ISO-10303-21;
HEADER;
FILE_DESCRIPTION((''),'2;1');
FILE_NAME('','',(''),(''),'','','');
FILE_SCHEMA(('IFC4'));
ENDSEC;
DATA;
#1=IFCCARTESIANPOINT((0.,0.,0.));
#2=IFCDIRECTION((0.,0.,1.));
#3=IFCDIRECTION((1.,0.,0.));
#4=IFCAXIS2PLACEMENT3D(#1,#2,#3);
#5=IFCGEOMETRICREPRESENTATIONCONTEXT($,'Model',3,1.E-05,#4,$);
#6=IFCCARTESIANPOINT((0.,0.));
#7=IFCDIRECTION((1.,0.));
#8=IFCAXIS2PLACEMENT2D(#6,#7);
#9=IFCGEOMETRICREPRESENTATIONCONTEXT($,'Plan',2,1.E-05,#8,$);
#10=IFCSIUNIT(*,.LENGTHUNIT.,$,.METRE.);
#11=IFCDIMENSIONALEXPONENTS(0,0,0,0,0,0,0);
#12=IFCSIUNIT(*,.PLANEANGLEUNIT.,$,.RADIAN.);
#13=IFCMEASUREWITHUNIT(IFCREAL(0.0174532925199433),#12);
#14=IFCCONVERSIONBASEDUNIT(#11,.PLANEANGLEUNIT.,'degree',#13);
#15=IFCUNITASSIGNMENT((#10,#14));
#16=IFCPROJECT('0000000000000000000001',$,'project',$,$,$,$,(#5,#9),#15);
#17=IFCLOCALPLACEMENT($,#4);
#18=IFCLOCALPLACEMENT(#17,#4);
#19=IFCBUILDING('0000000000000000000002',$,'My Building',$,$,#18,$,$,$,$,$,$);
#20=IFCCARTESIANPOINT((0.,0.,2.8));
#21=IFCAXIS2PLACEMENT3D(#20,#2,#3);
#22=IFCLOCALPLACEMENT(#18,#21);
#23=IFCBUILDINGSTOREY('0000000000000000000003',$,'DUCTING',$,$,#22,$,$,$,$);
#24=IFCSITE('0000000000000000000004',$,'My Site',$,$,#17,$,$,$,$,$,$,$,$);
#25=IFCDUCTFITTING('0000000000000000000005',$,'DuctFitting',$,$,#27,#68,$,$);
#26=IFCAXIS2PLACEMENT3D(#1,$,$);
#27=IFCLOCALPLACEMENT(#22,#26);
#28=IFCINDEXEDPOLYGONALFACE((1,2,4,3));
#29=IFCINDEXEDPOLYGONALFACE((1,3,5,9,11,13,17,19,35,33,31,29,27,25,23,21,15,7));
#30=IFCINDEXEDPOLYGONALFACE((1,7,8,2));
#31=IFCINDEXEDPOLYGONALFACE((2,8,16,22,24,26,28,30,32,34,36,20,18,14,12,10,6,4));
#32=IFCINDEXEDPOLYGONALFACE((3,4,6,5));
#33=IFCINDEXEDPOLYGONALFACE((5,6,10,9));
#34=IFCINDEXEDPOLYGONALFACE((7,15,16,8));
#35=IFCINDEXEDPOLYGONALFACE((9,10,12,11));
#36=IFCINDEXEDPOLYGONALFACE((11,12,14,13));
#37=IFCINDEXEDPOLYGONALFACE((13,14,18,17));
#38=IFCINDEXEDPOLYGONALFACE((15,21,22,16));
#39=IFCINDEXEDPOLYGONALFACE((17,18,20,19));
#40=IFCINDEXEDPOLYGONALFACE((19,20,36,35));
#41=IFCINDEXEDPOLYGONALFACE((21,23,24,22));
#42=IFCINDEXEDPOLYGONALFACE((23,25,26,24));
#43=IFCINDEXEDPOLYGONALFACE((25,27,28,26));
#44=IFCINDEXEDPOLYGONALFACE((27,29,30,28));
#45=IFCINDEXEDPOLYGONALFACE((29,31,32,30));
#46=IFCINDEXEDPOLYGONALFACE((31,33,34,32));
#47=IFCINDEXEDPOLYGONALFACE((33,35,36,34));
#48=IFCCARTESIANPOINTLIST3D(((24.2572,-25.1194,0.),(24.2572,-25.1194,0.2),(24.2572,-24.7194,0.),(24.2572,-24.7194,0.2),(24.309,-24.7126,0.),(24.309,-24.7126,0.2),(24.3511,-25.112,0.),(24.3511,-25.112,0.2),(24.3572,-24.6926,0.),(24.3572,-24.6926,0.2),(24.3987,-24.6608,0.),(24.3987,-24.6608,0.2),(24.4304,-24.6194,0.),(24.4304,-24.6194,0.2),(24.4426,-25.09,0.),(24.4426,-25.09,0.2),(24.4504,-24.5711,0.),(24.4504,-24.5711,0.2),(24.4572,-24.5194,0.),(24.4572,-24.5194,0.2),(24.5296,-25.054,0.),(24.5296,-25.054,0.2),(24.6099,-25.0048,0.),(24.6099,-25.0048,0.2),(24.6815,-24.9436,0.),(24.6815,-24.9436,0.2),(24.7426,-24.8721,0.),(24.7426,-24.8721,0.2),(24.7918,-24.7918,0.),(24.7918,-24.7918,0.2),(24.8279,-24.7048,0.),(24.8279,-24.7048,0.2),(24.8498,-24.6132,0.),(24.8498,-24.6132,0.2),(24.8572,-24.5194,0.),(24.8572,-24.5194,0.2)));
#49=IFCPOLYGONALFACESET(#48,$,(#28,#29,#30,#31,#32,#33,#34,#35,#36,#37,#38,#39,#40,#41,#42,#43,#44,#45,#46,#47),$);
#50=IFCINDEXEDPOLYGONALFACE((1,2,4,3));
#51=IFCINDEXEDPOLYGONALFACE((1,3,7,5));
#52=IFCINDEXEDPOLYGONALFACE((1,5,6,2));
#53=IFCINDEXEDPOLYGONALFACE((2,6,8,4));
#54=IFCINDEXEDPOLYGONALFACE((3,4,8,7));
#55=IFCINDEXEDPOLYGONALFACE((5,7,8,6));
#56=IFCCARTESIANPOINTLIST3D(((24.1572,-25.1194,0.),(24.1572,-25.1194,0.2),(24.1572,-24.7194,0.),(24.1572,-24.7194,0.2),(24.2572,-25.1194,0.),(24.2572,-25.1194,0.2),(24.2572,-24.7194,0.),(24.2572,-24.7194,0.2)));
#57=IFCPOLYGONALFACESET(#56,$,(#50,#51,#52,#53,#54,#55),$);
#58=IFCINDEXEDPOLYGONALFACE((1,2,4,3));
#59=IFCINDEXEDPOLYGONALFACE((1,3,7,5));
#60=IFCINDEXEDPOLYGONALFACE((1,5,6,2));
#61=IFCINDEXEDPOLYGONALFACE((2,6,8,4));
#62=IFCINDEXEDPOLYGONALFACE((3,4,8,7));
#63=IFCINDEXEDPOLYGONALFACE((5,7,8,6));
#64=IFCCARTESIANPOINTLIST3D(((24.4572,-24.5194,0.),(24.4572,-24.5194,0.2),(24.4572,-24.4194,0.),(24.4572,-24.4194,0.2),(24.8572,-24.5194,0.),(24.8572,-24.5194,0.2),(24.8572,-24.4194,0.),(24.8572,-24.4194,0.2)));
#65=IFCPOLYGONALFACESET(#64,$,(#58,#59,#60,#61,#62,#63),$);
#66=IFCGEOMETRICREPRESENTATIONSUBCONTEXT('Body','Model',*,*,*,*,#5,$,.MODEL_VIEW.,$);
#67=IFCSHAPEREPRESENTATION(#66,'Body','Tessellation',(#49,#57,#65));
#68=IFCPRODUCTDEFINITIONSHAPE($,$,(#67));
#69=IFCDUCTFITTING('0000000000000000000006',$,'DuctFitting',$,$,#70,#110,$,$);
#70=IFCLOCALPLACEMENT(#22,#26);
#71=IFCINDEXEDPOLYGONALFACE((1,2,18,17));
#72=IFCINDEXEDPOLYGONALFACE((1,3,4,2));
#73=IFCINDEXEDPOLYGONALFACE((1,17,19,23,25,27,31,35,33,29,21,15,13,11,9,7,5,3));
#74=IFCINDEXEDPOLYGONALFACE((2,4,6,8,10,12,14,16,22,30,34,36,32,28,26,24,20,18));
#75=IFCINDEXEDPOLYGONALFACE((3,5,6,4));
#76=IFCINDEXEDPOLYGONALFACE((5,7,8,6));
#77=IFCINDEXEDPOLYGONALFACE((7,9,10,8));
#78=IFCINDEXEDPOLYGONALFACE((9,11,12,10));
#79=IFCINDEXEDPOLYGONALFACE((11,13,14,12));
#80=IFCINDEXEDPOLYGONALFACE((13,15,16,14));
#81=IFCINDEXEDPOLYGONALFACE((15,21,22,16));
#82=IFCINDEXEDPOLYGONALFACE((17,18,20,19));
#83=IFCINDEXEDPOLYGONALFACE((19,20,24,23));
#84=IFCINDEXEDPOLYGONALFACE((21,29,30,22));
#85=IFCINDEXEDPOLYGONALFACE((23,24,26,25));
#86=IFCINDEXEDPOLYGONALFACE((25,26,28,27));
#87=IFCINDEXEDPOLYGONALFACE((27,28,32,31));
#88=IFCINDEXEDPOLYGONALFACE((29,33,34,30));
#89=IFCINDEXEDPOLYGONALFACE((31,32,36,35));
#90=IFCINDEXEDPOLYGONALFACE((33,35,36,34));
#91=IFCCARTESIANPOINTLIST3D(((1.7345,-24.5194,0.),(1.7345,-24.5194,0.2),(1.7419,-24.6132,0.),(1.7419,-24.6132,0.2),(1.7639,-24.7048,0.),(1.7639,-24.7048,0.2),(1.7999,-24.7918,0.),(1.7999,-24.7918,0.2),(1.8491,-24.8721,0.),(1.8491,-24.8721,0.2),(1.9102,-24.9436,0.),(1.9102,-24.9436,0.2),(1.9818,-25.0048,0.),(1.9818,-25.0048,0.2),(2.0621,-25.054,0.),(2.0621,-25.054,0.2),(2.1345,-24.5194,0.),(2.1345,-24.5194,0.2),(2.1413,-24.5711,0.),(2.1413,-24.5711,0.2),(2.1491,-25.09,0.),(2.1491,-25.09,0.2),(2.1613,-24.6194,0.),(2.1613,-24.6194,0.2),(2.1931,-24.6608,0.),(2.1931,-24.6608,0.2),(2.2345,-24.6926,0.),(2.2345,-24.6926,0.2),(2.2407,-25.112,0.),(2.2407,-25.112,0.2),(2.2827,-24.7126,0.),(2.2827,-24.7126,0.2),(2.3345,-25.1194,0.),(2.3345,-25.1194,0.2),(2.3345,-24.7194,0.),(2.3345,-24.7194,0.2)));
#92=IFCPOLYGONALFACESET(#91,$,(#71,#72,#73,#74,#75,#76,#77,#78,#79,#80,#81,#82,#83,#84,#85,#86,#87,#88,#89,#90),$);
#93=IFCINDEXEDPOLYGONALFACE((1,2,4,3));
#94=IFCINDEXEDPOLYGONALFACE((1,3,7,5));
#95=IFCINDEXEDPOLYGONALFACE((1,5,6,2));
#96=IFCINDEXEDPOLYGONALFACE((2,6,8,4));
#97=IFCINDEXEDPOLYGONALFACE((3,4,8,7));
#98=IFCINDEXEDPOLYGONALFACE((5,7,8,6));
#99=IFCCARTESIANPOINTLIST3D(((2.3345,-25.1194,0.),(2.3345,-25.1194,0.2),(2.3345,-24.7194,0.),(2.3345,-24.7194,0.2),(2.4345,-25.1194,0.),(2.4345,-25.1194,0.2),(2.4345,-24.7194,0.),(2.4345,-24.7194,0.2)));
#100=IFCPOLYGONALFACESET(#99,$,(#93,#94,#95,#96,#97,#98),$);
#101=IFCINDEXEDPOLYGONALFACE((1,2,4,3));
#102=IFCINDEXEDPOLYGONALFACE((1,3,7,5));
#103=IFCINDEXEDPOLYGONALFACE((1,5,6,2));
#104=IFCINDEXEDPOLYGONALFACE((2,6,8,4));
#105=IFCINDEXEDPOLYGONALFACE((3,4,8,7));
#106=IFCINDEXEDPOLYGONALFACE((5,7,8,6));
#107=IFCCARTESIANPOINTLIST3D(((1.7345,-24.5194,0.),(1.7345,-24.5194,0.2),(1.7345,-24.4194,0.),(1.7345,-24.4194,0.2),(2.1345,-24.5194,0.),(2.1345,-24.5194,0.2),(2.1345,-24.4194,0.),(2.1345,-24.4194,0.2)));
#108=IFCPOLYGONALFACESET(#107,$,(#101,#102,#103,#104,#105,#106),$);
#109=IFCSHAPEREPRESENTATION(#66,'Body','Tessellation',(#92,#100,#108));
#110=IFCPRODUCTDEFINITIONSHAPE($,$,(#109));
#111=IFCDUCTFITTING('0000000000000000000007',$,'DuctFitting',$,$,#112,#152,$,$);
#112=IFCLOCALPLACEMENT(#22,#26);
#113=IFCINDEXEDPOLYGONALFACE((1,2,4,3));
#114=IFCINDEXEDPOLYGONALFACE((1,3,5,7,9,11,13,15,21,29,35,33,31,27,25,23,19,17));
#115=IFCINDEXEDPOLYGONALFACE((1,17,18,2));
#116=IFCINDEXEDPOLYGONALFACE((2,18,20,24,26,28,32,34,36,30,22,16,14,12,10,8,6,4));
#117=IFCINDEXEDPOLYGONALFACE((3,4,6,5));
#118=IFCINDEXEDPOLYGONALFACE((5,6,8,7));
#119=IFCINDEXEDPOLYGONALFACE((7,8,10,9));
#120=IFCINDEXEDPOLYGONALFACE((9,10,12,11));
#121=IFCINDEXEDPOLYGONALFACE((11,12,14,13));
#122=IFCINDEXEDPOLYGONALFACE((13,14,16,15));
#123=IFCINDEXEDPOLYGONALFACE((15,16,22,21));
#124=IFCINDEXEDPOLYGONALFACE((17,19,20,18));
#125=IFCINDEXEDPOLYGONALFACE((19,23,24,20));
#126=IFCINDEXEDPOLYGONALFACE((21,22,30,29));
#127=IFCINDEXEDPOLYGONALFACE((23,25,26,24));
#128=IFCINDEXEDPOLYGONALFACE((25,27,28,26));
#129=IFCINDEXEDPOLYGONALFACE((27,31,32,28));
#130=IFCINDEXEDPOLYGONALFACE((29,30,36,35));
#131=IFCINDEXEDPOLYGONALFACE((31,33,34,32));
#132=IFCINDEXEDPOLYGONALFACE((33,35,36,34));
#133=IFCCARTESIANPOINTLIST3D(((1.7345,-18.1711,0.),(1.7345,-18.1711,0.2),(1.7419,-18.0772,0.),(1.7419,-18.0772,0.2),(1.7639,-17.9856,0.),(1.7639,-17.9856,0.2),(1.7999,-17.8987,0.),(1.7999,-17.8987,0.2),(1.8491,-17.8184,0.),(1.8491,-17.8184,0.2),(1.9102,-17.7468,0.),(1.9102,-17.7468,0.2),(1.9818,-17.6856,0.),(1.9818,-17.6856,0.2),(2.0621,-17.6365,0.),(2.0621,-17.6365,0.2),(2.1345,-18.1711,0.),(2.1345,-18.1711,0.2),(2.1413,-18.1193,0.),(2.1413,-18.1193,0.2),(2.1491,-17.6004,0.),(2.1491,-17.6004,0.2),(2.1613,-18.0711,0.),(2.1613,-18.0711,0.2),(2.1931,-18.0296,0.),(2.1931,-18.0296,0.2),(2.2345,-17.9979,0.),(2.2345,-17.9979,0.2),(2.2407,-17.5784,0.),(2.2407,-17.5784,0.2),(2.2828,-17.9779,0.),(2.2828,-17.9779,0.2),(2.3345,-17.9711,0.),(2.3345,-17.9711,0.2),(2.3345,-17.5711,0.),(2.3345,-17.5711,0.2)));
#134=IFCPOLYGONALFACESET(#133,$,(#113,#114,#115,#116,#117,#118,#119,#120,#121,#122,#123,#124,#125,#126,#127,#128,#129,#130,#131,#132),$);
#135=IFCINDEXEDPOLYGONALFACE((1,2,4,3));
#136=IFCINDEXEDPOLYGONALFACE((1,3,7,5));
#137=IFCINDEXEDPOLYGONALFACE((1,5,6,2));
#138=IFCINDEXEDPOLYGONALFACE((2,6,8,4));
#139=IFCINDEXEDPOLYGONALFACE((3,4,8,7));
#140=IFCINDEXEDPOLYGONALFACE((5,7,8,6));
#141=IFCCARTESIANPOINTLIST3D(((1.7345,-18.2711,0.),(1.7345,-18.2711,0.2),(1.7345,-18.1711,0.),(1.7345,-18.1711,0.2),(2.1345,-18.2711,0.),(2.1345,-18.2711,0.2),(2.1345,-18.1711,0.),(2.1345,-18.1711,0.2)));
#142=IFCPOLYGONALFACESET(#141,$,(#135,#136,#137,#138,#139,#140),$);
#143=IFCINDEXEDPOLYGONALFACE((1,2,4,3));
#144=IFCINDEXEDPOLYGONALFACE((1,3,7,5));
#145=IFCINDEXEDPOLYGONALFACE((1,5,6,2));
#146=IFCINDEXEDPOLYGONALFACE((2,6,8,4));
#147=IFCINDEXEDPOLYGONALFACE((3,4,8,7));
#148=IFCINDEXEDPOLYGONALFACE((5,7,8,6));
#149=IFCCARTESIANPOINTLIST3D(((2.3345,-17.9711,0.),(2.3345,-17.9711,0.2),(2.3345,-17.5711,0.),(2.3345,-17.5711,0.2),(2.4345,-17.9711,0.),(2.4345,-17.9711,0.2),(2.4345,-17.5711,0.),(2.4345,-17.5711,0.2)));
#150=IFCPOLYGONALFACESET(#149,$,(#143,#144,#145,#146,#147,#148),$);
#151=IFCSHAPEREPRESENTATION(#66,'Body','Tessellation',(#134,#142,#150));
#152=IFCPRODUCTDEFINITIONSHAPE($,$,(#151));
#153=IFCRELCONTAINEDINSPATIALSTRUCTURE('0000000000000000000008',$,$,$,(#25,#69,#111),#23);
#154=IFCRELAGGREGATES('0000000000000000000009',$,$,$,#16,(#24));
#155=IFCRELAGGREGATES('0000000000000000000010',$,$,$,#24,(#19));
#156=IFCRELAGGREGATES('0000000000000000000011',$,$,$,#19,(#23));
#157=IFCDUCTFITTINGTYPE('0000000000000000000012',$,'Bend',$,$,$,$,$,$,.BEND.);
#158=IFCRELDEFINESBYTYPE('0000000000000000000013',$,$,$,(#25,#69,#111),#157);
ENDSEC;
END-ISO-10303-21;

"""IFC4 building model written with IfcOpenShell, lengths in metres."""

from ifc_helpers import new_model, entity, si_unit, converted_unit, frame, origin_with_axes, origin_2d_with_axis, place, context, subcontext, project, spatial, line, arc, indexed_curve, rectangle, outline, extrude, source, transform, mapped, type_object, type_shapes, element, save


model = new_model("IFC4")

# Units and contexts
model_context = context("Model", 3, precision=1e-05, world=origin_with_axes())
plan_context = context("Plan", 2, precision=1e-05, world=origin_2d_with_axis())
body_context = subcontext(model_context, "Body", "Model", "MODEL_VIEW")
ifc_project = project(units=[si_unit("LENGTHUNIT", "METRE"), converted_unit("PLANEANGLEUNIT", "degree", entity("IfcReal", 0.0174532925199433), si_unit("PLANEANGLEUNIT", "RADIAN"), dimensions=[0, 0, 0, 0, 0, 0, 0])], contexts=[model_context, plan_context])

# Site, building, storey
site_placement = place(None, origin_with_axes())
site = spatial("IfcSite", under=ifc_project, at=site_placement, Name="My Site")
building_placement = place(site_placement, origin_with_axes())
building = spatial("IfcBuilding", under=site, at=building_placement, Name="My Building")
storey_placement = place(building_placement, frame((0.0, 0.0, 2.8), z_axis=(0.0, 0.0, 1.0), x_axis=(1.0, 0.0, 0.0)))
storey = spatial("IfcBuildingStorey", under=building, at=storey_placement, Name="DUCTING")

# Duct fittings
duct_fitting_type = type_object("IfcDuctFittingType", Name="Bend", PredefinedType="BEND")
shared_shape = source(origin_with_axes(), body_context, "Body", "SweptSolid", [
    extrude(outline(indexed_curve([(-0.2, 0.0), (-0.2586, -0.1414), (-0.4, -0.2), (-0.4, -0.6), (0.0243, -0.4243), (0.2, 0.0)], segments=[arc(1, 2, 3), line(3, 4), arc(4, 5, 6), line(6, 1)])), frame((0.0, -0.1, -0.1), z_axis=(0.0, -1.0, 0.0), x_axis=(1.0, 0.0, 0.0)), (0.0, 0.0, -1.0), 0.2),
    extrude(rectangle(XDim=0.4, YDim=0.2), origin_with_axes(), (0.0, 0.0, -1.0), 0.1),
    extrude(rectangle(XDim=0.4, YDim=0.2), frame((-0.4, 0.0, -0.5), z_axis=(-1.0, 0.0, 0.0), x_axis=(0.0, 0.0, -1.0)), (0.0, 0.0, 1.0), 0.1),
])
type_shapes(duct_fitting_type, [shared_shape])
for number, where, z_axis, x_axis, name in (
    (1, (24.1572, -24.9194, 0.1), (-1.0, 0.0, 0.0), (0.0, -1.0, 0.0), "DuctFitting"),
    (2, (2.4345, -24.9194, 0.1), (1.0, 0.0, 0.0), (0.0, -1.0, 0.0), "DuctFitting"),
    (3, (1.9345, -18.2711, 0.1), (0.0, -1.0, 0.0), (-1.0, 0.0, 0.0), "DuctFitting"),
):
    element("IfcDuctFitting", number, at=place(storey_placement, frame(where, z_axis=z_axis, x_axis=x_axis)), inside=storey, type_object=duct_fitting_type, Name=name, context=body_context, shape_type="MappedRepresentation", body=[
        mapped(shared_shape, transform((0.0, 0.0, 0.0), x_axis=(1.0, 0.0, 0.0), y_axis=(0.0, 1.0, 0.0), z_axis=(0.0, 0.0, 1.0), scale=1.0)),
    ])

save(model, "model.ifc")
